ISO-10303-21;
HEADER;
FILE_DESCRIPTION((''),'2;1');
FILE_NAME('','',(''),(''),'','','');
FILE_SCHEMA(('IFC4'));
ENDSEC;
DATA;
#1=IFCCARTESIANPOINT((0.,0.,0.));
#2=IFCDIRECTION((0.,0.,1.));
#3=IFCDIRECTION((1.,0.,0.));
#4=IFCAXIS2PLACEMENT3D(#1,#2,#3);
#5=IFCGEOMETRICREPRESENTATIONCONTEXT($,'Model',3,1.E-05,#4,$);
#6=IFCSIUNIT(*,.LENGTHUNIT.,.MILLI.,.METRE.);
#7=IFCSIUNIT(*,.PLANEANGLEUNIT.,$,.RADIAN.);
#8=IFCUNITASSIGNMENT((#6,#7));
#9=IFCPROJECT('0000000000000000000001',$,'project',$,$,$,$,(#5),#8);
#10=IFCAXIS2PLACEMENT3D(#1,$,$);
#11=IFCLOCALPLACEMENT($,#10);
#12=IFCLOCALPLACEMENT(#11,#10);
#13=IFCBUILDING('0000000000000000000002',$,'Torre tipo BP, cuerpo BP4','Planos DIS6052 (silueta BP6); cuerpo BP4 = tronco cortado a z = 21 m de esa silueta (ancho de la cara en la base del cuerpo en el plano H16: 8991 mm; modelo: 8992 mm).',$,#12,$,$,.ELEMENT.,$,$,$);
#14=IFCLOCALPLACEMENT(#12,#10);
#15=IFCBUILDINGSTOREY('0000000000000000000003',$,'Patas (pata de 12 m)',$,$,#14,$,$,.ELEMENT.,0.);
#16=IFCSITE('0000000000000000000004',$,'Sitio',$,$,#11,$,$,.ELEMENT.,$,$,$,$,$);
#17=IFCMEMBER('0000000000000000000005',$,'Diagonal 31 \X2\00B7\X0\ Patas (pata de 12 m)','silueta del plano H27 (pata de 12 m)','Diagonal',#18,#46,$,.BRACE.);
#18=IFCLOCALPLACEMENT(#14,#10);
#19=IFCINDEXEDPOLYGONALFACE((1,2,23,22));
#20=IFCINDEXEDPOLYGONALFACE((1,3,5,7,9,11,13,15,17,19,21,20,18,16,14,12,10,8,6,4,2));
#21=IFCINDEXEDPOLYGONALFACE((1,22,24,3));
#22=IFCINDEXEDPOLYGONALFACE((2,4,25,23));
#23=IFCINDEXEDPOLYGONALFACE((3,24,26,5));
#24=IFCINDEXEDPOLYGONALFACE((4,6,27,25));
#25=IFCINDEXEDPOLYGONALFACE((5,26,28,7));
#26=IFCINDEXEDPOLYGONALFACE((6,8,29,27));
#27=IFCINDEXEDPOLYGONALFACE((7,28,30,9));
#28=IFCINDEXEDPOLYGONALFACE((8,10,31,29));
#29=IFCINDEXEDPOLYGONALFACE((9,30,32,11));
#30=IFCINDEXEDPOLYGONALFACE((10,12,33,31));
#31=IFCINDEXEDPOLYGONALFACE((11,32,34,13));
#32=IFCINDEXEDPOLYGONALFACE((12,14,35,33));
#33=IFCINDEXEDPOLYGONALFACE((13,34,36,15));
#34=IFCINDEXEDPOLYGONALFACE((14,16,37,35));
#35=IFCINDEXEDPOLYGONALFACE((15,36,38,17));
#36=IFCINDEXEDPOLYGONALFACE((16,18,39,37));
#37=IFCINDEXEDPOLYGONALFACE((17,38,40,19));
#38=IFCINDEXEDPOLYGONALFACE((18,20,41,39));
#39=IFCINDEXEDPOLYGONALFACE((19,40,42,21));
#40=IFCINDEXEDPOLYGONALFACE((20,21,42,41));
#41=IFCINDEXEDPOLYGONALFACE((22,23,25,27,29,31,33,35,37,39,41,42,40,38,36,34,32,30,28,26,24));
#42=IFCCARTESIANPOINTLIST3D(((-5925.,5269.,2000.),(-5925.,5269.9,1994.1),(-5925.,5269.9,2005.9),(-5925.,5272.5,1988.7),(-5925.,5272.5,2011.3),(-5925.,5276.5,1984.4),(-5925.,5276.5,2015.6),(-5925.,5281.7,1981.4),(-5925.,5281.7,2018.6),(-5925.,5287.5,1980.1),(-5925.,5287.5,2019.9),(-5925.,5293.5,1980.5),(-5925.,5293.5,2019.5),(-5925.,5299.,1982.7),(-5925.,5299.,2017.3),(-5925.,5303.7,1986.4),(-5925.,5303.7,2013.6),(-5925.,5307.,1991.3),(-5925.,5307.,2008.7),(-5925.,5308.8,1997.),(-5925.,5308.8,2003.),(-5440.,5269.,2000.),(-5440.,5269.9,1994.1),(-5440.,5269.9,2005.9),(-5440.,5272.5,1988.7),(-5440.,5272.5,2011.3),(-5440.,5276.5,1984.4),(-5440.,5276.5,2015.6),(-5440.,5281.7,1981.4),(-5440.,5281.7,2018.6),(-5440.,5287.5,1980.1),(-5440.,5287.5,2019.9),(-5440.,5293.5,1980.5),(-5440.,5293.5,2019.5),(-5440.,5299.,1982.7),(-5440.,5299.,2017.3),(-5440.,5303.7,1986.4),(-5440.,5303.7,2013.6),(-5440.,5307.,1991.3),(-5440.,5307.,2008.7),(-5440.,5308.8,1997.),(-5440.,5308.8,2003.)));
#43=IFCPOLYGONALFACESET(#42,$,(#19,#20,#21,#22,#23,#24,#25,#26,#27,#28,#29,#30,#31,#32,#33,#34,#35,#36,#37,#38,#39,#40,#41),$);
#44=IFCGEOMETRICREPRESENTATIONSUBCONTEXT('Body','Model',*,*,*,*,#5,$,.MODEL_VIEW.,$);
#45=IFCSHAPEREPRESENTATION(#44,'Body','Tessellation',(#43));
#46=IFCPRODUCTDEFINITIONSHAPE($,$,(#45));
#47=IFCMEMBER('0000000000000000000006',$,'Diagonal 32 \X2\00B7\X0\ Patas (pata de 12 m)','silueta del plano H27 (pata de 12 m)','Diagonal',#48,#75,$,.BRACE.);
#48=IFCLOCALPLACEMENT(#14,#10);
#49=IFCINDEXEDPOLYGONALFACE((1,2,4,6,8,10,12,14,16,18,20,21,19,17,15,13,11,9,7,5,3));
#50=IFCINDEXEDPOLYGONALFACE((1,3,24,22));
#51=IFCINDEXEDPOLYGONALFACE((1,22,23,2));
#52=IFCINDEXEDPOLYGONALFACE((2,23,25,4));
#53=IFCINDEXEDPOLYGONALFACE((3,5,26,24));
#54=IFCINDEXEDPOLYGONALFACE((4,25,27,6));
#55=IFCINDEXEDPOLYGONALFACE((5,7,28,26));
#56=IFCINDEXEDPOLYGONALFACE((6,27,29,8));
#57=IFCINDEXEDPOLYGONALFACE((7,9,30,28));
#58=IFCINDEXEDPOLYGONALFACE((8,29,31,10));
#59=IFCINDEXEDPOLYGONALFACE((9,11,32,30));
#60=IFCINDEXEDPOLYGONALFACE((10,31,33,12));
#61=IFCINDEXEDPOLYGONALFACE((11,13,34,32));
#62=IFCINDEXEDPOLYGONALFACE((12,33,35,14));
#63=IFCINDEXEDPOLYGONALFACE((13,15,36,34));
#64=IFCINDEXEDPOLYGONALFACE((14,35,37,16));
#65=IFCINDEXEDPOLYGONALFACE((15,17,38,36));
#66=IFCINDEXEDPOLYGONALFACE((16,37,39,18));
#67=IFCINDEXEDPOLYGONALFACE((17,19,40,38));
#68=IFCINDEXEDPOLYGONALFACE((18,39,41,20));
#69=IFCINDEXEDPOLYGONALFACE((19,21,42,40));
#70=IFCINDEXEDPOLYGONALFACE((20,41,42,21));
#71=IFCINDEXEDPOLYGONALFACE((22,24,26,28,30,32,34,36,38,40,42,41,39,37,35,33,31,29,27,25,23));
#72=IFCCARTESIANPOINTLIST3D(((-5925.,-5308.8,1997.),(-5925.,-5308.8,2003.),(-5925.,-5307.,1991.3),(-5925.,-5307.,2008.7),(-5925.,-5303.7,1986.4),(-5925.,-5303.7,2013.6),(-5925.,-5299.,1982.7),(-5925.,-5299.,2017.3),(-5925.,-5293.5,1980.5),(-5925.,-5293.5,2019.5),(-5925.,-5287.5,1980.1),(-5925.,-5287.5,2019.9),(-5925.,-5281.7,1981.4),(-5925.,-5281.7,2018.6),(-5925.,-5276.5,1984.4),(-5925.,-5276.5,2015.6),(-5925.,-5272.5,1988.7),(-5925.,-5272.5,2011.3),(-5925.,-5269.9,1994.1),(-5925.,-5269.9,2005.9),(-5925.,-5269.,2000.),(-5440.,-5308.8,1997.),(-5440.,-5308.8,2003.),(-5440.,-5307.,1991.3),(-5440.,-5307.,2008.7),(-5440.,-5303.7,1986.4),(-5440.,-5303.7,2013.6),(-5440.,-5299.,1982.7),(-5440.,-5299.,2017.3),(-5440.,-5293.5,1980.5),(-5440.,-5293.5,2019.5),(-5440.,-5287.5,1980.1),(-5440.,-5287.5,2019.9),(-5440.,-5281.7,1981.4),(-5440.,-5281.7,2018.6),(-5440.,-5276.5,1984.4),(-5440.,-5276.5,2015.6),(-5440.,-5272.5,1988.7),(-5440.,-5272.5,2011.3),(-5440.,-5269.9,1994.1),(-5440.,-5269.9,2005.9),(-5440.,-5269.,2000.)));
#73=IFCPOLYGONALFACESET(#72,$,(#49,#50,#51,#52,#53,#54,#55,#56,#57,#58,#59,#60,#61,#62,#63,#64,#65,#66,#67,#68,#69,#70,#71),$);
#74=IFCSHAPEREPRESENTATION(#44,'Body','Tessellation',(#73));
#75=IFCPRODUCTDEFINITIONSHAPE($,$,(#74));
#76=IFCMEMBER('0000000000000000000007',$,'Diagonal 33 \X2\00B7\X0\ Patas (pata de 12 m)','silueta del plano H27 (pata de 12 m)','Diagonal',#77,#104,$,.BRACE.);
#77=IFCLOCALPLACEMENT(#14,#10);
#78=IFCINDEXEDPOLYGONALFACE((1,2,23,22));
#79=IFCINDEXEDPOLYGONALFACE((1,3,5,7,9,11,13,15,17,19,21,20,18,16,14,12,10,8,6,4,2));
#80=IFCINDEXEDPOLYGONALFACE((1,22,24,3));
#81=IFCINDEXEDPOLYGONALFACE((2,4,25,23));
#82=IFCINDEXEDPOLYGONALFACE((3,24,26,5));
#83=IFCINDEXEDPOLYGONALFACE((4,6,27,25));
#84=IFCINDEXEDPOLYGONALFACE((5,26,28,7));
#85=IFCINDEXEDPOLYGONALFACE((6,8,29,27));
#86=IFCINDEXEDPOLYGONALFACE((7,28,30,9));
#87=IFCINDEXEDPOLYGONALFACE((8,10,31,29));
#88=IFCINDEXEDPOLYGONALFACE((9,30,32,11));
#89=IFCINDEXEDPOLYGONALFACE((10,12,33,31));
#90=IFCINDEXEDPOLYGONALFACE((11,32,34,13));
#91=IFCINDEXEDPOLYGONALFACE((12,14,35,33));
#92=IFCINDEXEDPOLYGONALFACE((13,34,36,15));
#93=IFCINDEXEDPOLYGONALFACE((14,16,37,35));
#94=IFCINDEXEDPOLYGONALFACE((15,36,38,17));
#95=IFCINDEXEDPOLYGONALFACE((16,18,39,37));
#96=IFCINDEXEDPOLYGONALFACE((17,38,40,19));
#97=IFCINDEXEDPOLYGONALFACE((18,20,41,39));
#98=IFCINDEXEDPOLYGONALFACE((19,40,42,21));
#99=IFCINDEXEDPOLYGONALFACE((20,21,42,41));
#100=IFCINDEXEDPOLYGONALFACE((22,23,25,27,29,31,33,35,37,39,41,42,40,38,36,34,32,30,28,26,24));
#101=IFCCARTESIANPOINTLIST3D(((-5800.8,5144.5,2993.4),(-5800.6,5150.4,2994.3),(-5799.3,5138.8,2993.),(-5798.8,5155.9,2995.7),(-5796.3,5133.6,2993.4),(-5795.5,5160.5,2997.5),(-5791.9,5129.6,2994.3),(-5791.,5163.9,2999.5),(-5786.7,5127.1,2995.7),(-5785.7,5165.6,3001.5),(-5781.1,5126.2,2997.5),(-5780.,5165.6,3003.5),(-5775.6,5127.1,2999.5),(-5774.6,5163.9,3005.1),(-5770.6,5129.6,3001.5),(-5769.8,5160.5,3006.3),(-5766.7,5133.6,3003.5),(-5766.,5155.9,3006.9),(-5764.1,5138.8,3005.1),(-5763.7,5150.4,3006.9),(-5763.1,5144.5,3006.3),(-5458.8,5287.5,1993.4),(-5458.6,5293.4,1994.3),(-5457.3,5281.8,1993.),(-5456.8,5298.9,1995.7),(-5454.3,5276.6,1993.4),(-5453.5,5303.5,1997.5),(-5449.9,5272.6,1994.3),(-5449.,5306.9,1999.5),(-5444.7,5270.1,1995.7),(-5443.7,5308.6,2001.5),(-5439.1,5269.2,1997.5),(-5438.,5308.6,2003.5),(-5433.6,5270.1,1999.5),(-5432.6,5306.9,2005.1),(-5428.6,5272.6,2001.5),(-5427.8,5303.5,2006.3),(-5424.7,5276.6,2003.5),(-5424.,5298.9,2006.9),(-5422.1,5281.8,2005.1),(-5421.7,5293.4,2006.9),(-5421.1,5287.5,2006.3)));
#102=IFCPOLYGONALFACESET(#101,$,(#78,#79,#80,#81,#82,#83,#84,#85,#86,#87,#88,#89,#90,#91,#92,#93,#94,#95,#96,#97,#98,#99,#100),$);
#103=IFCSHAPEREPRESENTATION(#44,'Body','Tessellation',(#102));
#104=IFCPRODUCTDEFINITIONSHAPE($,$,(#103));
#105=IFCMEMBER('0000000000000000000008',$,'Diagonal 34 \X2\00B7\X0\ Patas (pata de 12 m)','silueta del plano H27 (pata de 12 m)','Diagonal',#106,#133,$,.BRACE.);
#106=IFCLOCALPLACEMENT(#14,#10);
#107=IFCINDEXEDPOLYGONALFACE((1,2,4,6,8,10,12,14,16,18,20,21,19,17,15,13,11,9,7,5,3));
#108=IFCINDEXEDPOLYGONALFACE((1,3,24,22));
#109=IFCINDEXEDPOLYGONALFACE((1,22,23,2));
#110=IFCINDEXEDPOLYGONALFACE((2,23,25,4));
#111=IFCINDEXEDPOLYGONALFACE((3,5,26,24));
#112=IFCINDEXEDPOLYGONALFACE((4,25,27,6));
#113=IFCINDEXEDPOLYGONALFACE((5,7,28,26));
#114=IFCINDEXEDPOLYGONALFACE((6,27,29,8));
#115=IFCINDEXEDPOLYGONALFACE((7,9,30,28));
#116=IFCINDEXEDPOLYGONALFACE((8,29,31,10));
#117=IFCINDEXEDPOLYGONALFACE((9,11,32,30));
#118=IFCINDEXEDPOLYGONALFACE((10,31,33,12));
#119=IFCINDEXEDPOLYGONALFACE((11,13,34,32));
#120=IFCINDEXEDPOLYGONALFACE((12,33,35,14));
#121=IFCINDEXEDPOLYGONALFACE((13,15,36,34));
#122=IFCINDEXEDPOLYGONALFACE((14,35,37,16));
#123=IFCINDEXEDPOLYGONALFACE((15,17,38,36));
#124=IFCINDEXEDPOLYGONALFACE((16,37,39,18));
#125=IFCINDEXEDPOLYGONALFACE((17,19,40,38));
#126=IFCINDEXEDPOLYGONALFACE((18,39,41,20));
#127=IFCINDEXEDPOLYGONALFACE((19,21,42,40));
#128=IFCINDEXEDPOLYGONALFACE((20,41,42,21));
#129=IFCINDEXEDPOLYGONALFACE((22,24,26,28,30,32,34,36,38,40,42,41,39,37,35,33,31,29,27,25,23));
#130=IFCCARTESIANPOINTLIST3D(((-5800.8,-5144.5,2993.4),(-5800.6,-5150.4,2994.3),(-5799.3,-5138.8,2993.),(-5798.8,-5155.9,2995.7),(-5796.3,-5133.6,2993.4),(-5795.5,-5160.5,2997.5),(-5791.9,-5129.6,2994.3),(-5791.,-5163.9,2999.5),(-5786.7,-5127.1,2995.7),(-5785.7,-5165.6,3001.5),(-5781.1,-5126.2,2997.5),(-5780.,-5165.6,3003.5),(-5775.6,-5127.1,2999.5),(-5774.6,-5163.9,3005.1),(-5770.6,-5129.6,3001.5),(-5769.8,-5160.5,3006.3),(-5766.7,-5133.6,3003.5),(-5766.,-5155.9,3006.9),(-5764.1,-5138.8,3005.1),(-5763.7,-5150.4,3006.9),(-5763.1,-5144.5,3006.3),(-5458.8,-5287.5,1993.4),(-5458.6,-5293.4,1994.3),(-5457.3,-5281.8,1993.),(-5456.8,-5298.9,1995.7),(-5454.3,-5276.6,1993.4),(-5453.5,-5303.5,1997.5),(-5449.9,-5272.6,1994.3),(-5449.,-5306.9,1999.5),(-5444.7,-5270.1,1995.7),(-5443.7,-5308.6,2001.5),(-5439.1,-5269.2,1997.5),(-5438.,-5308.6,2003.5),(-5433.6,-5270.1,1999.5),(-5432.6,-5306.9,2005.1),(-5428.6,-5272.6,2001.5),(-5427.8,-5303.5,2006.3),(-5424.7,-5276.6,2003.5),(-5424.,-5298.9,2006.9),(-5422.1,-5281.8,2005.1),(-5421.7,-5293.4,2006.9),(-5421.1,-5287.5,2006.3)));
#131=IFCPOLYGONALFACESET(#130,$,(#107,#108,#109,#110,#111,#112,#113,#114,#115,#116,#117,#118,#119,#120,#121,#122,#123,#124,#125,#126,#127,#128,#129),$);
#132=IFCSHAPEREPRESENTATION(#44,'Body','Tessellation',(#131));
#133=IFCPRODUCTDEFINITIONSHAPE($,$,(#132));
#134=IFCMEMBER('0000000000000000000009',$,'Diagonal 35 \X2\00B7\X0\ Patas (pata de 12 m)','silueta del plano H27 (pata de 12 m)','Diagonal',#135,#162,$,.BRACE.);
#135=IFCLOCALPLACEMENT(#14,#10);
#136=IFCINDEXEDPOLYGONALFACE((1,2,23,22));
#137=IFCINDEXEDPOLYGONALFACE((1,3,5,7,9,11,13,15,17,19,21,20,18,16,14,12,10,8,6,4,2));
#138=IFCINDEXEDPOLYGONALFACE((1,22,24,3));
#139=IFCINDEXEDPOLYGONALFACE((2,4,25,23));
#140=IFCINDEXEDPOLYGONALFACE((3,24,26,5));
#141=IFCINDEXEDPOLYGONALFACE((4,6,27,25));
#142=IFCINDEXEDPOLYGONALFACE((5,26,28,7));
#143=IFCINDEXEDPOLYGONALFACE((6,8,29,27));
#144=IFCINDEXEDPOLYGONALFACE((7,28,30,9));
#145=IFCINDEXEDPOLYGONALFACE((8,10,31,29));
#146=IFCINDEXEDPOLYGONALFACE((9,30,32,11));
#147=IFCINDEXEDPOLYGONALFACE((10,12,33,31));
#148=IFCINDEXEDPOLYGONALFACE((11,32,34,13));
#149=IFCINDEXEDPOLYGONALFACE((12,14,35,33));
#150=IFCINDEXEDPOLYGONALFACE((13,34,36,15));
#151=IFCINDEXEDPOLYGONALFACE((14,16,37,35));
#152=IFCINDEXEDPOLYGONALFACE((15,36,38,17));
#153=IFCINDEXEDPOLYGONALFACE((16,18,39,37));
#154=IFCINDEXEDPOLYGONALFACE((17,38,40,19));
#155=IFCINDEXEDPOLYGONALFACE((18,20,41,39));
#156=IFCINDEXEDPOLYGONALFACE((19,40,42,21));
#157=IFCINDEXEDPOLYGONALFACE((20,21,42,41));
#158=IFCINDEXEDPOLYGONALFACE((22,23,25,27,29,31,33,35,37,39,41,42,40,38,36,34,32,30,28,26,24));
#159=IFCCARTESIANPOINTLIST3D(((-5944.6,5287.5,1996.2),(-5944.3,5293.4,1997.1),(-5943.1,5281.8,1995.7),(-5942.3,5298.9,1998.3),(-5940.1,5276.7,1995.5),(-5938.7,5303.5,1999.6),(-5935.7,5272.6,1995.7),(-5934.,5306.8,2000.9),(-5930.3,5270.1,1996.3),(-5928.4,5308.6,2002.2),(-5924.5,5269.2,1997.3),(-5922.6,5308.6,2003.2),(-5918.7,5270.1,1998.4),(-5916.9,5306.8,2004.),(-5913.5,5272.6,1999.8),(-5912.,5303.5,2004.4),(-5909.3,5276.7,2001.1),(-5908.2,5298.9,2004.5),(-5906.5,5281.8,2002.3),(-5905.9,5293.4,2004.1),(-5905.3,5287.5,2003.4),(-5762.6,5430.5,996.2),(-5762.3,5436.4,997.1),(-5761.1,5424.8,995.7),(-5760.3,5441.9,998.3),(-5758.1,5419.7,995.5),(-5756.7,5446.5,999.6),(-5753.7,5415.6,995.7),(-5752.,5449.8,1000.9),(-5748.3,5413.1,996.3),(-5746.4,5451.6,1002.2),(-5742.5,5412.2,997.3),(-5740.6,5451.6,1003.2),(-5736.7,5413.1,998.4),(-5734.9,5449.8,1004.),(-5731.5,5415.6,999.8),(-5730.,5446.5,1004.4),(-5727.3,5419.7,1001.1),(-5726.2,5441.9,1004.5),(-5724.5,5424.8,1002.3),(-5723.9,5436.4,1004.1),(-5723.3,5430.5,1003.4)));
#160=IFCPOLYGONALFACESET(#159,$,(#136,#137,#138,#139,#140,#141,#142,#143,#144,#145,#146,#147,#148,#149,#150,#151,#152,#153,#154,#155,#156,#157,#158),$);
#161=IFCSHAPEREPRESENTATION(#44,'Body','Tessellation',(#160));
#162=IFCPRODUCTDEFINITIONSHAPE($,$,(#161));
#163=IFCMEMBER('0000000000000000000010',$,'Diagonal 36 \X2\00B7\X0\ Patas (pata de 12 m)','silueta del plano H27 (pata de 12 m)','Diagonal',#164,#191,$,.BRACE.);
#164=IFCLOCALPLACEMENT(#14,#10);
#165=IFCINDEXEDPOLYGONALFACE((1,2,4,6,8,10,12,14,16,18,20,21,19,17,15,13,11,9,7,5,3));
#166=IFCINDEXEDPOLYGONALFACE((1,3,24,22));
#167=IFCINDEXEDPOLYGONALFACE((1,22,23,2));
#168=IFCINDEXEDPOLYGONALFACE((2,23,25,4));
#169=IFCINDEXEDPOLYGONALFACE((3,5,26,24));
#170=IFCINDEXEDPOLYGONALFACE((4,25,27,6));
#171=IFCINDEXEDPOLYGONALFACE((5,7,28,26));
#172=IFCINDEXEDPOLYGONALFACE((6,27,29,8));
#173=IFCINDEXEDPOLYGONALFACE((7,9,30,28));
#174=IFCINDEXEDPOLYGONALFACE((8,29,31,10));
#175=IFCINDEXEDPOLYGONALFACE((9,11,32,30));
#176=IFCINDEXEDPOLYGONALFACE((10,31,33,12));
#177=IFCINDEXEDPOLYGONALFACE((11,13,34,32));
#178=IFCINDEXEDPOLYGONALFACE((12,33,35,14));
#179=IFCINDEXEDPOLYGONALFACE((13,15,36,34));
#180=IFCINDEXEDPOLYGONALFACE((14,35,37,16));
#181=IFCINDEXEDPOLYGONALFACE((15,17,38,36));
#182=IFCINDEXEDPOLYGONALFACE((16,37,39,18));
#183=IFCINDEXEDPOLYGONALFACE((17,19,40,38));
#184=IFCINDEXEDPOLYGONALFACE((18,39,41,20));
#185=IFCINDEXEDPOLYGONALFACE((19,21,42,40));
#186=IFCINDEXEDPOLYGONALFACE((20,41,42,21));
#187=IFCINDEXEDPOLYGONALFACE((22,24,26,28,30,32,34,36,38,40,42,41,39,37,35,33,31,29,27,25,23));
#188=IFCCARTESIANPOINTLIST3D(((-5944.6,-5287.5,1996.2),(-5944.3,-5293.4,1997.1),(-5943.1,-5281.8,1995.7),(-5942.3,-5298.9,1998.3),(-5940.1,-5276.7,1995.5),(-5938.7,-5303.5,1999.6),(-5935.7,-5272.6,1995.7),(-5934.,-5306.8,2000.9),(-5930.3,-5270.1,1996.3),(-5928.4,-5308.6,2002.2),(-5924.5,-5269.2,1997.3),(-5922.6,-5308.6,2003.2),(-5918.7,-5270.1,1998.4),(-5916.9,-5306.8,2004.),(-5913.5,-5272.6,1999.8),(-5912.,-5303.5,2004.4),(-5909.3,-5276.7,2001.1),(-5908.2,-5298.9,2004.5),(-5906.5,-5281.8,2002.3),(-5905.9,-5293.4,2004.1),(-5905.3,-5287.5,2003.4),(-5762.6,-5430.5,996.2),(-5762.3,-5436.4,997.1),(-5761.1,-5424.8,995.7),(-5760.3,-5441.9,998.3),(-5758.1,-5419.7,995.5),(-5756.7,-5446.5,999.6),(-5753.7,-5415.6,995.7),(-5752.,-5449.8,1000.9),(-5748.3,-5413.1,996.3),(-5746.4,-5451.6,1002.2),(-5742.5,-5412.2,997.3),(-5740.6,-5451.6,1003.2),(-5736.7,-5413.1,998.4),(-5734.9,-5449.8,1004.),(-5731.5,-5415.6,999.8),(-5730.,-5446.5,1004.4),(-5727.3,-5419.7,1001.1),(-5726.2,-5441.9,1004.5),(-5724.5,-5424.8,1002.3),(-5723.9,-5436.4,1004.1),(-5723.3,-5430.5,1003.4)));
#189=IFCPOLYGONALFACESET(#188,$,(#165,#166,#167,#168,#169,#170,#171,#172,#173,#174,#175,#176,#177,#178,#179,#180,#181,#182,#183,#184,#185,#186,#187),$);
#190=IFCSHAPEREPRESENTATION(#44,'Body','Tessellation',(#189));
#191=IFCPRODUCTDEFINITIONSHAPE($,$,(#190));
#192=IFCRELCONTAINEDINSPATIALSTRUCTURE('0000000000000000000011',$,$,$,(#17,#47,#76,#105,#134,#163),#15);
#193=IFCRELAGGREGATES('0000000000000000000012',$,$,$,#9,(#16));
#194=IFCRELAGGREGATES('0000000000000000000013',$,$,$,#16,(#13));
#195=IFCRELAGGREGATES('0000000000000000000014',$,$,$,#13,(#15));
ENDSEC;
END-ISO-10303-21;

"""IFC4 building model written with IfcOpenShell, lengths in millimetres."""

from ifc_helpers import new_model, si_unit, frame, origin, origin_with_axes, place, context, subcontext, project, spatial, circle, extrude, element, save


model = new_model("IFC4")

# Units and contexts
model_context = context("Model", 3, precision=1e-05, world=origin_with_axes())
body_context = subcontext(model_context, "Body", "Model", "MODEL_VIEW")
ifc_project = project(units=[si_unit("LENGTHUNIT", "METRE", prefix="MILLI"), si_unit("PLANEANGLEUNIT", "RADIAN")], contexts=[model_context])

# Site, building, storey
site_placement = place(None, origin())
site = spatial("IfcSite", under=ifc_project, at=site_placement, Name="Sitio", CompositionType="ELEMENT")
building_placement = place(site_placement, origin())
building = spatial("IfcBuilding", under=site, at=building_placement, Name="Torre tipo BP, cuerpo BP4", Description="Planos DIS6052 (silueta BP6); cuerpo BP4 = tronco cortado a z = 21 m de esa silueta (ancho de la cara en la base del cuerpo en el plano H16: 8991 mm; modelo: 8992 mm).", CompositionType="ELEMENT")
storey_placement = place(building_placement, origin())
storey = spatial("IfcBuildingStorey", under=building, at=storey_placement, Name="Patas (pata de 12 m)", CompositionType="ELEMENT", Elevation=0.0)

# Members
for number, where, z_axis, x_axis, name in (
    (1, (-5925.0, 5289.0, 2000.0), (1.0, 0.0, 0.0), (0.0, -1.0, 0.0), "Diagonal 31 · Patas (pata de 12 m)"),
    (2, (-5925.0, -5289.0, 2000.0), (1.0, 0.0, 0.0), (0.0, 1.0, 0.0), "Diagonal 32 · Patas (pata de 12 m)"),
):
    element("IfcMember", number, at=place(storey_placement, frame(where, z_axis=z_axis, x_axis=x_axis)), inside=storey, Name=name, Description="silueta del plano H27 (pata de 12 m)", ObjectType="Diagonal", PredefinedType="BRACE", context=body_context, shape_type="SweptSolid", body=[
        extrude(circle(Radius=20.0), None, (0.0, 0.0, 1.0), 485.0),
    ])
for number, where, z_axis, x_axis, name in (
    (3, (-5440.0, 5289.0, 2000.0), (-0.320676, -0.134084, 0.93765), (0.043389, -0.99097, -0.12687), "Diagonal 33 · Patas (pata de 12 m)"),
    (4, (-5440.0, -5289.0, 2000.0), (-0.320676, 0.134084, 0.93765), (0.043389, 0.99097, -0.12687), "Diagonal 34 · Patas (pata de 12 m)"),
):
    element("IfcMember", number, at=place(storey_placement, frame(where, z_axis=z_axis, x_axis=x_axis)), inside=storey, Name=name, Description="silueta del plano H27 (pata de 12 m)", ObjectType="Diagonal", PredefinedType="BRACE", context=body_context, shape_type="SweptSolid", body=[
        extrude(circle(Radius=20.0), None, (0.0, 0.0, 1.0), 1066.5),
    ])
for number, where, z_axis, x_axis, name in (
    (5, (-5743.0, 5432.0, 1000.0), (-0.177312, -0.139317, 0.974244), (0.024946, -0.990248, -0.137065), "Diagonal 35 · Patas (pata de 12 m)"),
    (6, (-5743.0, -5432.0, 1000.0), (-0.177312, 0.139317, 0.974244), (0.024946, 0.990248, -0.137065), "Diagonal 36 · Patas (pata de 12 m)"),
):
    element("IfcMember", number, at=place(storey_placement, frame(where, z_axis=z_axis, x_axis=x_axis)), inside=storey, Name=name, Description="silueta del plano H27 (pata de 12 m)", ObjectType="Diagonal", PredefinedType="BRACE", context=body_context, shape_type="SweptSolid", body=[
        extrude(circle(Radius=20.0), None, (0.0, 0.0, 1.0), 1026.4),
    ])

save(model, "model.ifc")
